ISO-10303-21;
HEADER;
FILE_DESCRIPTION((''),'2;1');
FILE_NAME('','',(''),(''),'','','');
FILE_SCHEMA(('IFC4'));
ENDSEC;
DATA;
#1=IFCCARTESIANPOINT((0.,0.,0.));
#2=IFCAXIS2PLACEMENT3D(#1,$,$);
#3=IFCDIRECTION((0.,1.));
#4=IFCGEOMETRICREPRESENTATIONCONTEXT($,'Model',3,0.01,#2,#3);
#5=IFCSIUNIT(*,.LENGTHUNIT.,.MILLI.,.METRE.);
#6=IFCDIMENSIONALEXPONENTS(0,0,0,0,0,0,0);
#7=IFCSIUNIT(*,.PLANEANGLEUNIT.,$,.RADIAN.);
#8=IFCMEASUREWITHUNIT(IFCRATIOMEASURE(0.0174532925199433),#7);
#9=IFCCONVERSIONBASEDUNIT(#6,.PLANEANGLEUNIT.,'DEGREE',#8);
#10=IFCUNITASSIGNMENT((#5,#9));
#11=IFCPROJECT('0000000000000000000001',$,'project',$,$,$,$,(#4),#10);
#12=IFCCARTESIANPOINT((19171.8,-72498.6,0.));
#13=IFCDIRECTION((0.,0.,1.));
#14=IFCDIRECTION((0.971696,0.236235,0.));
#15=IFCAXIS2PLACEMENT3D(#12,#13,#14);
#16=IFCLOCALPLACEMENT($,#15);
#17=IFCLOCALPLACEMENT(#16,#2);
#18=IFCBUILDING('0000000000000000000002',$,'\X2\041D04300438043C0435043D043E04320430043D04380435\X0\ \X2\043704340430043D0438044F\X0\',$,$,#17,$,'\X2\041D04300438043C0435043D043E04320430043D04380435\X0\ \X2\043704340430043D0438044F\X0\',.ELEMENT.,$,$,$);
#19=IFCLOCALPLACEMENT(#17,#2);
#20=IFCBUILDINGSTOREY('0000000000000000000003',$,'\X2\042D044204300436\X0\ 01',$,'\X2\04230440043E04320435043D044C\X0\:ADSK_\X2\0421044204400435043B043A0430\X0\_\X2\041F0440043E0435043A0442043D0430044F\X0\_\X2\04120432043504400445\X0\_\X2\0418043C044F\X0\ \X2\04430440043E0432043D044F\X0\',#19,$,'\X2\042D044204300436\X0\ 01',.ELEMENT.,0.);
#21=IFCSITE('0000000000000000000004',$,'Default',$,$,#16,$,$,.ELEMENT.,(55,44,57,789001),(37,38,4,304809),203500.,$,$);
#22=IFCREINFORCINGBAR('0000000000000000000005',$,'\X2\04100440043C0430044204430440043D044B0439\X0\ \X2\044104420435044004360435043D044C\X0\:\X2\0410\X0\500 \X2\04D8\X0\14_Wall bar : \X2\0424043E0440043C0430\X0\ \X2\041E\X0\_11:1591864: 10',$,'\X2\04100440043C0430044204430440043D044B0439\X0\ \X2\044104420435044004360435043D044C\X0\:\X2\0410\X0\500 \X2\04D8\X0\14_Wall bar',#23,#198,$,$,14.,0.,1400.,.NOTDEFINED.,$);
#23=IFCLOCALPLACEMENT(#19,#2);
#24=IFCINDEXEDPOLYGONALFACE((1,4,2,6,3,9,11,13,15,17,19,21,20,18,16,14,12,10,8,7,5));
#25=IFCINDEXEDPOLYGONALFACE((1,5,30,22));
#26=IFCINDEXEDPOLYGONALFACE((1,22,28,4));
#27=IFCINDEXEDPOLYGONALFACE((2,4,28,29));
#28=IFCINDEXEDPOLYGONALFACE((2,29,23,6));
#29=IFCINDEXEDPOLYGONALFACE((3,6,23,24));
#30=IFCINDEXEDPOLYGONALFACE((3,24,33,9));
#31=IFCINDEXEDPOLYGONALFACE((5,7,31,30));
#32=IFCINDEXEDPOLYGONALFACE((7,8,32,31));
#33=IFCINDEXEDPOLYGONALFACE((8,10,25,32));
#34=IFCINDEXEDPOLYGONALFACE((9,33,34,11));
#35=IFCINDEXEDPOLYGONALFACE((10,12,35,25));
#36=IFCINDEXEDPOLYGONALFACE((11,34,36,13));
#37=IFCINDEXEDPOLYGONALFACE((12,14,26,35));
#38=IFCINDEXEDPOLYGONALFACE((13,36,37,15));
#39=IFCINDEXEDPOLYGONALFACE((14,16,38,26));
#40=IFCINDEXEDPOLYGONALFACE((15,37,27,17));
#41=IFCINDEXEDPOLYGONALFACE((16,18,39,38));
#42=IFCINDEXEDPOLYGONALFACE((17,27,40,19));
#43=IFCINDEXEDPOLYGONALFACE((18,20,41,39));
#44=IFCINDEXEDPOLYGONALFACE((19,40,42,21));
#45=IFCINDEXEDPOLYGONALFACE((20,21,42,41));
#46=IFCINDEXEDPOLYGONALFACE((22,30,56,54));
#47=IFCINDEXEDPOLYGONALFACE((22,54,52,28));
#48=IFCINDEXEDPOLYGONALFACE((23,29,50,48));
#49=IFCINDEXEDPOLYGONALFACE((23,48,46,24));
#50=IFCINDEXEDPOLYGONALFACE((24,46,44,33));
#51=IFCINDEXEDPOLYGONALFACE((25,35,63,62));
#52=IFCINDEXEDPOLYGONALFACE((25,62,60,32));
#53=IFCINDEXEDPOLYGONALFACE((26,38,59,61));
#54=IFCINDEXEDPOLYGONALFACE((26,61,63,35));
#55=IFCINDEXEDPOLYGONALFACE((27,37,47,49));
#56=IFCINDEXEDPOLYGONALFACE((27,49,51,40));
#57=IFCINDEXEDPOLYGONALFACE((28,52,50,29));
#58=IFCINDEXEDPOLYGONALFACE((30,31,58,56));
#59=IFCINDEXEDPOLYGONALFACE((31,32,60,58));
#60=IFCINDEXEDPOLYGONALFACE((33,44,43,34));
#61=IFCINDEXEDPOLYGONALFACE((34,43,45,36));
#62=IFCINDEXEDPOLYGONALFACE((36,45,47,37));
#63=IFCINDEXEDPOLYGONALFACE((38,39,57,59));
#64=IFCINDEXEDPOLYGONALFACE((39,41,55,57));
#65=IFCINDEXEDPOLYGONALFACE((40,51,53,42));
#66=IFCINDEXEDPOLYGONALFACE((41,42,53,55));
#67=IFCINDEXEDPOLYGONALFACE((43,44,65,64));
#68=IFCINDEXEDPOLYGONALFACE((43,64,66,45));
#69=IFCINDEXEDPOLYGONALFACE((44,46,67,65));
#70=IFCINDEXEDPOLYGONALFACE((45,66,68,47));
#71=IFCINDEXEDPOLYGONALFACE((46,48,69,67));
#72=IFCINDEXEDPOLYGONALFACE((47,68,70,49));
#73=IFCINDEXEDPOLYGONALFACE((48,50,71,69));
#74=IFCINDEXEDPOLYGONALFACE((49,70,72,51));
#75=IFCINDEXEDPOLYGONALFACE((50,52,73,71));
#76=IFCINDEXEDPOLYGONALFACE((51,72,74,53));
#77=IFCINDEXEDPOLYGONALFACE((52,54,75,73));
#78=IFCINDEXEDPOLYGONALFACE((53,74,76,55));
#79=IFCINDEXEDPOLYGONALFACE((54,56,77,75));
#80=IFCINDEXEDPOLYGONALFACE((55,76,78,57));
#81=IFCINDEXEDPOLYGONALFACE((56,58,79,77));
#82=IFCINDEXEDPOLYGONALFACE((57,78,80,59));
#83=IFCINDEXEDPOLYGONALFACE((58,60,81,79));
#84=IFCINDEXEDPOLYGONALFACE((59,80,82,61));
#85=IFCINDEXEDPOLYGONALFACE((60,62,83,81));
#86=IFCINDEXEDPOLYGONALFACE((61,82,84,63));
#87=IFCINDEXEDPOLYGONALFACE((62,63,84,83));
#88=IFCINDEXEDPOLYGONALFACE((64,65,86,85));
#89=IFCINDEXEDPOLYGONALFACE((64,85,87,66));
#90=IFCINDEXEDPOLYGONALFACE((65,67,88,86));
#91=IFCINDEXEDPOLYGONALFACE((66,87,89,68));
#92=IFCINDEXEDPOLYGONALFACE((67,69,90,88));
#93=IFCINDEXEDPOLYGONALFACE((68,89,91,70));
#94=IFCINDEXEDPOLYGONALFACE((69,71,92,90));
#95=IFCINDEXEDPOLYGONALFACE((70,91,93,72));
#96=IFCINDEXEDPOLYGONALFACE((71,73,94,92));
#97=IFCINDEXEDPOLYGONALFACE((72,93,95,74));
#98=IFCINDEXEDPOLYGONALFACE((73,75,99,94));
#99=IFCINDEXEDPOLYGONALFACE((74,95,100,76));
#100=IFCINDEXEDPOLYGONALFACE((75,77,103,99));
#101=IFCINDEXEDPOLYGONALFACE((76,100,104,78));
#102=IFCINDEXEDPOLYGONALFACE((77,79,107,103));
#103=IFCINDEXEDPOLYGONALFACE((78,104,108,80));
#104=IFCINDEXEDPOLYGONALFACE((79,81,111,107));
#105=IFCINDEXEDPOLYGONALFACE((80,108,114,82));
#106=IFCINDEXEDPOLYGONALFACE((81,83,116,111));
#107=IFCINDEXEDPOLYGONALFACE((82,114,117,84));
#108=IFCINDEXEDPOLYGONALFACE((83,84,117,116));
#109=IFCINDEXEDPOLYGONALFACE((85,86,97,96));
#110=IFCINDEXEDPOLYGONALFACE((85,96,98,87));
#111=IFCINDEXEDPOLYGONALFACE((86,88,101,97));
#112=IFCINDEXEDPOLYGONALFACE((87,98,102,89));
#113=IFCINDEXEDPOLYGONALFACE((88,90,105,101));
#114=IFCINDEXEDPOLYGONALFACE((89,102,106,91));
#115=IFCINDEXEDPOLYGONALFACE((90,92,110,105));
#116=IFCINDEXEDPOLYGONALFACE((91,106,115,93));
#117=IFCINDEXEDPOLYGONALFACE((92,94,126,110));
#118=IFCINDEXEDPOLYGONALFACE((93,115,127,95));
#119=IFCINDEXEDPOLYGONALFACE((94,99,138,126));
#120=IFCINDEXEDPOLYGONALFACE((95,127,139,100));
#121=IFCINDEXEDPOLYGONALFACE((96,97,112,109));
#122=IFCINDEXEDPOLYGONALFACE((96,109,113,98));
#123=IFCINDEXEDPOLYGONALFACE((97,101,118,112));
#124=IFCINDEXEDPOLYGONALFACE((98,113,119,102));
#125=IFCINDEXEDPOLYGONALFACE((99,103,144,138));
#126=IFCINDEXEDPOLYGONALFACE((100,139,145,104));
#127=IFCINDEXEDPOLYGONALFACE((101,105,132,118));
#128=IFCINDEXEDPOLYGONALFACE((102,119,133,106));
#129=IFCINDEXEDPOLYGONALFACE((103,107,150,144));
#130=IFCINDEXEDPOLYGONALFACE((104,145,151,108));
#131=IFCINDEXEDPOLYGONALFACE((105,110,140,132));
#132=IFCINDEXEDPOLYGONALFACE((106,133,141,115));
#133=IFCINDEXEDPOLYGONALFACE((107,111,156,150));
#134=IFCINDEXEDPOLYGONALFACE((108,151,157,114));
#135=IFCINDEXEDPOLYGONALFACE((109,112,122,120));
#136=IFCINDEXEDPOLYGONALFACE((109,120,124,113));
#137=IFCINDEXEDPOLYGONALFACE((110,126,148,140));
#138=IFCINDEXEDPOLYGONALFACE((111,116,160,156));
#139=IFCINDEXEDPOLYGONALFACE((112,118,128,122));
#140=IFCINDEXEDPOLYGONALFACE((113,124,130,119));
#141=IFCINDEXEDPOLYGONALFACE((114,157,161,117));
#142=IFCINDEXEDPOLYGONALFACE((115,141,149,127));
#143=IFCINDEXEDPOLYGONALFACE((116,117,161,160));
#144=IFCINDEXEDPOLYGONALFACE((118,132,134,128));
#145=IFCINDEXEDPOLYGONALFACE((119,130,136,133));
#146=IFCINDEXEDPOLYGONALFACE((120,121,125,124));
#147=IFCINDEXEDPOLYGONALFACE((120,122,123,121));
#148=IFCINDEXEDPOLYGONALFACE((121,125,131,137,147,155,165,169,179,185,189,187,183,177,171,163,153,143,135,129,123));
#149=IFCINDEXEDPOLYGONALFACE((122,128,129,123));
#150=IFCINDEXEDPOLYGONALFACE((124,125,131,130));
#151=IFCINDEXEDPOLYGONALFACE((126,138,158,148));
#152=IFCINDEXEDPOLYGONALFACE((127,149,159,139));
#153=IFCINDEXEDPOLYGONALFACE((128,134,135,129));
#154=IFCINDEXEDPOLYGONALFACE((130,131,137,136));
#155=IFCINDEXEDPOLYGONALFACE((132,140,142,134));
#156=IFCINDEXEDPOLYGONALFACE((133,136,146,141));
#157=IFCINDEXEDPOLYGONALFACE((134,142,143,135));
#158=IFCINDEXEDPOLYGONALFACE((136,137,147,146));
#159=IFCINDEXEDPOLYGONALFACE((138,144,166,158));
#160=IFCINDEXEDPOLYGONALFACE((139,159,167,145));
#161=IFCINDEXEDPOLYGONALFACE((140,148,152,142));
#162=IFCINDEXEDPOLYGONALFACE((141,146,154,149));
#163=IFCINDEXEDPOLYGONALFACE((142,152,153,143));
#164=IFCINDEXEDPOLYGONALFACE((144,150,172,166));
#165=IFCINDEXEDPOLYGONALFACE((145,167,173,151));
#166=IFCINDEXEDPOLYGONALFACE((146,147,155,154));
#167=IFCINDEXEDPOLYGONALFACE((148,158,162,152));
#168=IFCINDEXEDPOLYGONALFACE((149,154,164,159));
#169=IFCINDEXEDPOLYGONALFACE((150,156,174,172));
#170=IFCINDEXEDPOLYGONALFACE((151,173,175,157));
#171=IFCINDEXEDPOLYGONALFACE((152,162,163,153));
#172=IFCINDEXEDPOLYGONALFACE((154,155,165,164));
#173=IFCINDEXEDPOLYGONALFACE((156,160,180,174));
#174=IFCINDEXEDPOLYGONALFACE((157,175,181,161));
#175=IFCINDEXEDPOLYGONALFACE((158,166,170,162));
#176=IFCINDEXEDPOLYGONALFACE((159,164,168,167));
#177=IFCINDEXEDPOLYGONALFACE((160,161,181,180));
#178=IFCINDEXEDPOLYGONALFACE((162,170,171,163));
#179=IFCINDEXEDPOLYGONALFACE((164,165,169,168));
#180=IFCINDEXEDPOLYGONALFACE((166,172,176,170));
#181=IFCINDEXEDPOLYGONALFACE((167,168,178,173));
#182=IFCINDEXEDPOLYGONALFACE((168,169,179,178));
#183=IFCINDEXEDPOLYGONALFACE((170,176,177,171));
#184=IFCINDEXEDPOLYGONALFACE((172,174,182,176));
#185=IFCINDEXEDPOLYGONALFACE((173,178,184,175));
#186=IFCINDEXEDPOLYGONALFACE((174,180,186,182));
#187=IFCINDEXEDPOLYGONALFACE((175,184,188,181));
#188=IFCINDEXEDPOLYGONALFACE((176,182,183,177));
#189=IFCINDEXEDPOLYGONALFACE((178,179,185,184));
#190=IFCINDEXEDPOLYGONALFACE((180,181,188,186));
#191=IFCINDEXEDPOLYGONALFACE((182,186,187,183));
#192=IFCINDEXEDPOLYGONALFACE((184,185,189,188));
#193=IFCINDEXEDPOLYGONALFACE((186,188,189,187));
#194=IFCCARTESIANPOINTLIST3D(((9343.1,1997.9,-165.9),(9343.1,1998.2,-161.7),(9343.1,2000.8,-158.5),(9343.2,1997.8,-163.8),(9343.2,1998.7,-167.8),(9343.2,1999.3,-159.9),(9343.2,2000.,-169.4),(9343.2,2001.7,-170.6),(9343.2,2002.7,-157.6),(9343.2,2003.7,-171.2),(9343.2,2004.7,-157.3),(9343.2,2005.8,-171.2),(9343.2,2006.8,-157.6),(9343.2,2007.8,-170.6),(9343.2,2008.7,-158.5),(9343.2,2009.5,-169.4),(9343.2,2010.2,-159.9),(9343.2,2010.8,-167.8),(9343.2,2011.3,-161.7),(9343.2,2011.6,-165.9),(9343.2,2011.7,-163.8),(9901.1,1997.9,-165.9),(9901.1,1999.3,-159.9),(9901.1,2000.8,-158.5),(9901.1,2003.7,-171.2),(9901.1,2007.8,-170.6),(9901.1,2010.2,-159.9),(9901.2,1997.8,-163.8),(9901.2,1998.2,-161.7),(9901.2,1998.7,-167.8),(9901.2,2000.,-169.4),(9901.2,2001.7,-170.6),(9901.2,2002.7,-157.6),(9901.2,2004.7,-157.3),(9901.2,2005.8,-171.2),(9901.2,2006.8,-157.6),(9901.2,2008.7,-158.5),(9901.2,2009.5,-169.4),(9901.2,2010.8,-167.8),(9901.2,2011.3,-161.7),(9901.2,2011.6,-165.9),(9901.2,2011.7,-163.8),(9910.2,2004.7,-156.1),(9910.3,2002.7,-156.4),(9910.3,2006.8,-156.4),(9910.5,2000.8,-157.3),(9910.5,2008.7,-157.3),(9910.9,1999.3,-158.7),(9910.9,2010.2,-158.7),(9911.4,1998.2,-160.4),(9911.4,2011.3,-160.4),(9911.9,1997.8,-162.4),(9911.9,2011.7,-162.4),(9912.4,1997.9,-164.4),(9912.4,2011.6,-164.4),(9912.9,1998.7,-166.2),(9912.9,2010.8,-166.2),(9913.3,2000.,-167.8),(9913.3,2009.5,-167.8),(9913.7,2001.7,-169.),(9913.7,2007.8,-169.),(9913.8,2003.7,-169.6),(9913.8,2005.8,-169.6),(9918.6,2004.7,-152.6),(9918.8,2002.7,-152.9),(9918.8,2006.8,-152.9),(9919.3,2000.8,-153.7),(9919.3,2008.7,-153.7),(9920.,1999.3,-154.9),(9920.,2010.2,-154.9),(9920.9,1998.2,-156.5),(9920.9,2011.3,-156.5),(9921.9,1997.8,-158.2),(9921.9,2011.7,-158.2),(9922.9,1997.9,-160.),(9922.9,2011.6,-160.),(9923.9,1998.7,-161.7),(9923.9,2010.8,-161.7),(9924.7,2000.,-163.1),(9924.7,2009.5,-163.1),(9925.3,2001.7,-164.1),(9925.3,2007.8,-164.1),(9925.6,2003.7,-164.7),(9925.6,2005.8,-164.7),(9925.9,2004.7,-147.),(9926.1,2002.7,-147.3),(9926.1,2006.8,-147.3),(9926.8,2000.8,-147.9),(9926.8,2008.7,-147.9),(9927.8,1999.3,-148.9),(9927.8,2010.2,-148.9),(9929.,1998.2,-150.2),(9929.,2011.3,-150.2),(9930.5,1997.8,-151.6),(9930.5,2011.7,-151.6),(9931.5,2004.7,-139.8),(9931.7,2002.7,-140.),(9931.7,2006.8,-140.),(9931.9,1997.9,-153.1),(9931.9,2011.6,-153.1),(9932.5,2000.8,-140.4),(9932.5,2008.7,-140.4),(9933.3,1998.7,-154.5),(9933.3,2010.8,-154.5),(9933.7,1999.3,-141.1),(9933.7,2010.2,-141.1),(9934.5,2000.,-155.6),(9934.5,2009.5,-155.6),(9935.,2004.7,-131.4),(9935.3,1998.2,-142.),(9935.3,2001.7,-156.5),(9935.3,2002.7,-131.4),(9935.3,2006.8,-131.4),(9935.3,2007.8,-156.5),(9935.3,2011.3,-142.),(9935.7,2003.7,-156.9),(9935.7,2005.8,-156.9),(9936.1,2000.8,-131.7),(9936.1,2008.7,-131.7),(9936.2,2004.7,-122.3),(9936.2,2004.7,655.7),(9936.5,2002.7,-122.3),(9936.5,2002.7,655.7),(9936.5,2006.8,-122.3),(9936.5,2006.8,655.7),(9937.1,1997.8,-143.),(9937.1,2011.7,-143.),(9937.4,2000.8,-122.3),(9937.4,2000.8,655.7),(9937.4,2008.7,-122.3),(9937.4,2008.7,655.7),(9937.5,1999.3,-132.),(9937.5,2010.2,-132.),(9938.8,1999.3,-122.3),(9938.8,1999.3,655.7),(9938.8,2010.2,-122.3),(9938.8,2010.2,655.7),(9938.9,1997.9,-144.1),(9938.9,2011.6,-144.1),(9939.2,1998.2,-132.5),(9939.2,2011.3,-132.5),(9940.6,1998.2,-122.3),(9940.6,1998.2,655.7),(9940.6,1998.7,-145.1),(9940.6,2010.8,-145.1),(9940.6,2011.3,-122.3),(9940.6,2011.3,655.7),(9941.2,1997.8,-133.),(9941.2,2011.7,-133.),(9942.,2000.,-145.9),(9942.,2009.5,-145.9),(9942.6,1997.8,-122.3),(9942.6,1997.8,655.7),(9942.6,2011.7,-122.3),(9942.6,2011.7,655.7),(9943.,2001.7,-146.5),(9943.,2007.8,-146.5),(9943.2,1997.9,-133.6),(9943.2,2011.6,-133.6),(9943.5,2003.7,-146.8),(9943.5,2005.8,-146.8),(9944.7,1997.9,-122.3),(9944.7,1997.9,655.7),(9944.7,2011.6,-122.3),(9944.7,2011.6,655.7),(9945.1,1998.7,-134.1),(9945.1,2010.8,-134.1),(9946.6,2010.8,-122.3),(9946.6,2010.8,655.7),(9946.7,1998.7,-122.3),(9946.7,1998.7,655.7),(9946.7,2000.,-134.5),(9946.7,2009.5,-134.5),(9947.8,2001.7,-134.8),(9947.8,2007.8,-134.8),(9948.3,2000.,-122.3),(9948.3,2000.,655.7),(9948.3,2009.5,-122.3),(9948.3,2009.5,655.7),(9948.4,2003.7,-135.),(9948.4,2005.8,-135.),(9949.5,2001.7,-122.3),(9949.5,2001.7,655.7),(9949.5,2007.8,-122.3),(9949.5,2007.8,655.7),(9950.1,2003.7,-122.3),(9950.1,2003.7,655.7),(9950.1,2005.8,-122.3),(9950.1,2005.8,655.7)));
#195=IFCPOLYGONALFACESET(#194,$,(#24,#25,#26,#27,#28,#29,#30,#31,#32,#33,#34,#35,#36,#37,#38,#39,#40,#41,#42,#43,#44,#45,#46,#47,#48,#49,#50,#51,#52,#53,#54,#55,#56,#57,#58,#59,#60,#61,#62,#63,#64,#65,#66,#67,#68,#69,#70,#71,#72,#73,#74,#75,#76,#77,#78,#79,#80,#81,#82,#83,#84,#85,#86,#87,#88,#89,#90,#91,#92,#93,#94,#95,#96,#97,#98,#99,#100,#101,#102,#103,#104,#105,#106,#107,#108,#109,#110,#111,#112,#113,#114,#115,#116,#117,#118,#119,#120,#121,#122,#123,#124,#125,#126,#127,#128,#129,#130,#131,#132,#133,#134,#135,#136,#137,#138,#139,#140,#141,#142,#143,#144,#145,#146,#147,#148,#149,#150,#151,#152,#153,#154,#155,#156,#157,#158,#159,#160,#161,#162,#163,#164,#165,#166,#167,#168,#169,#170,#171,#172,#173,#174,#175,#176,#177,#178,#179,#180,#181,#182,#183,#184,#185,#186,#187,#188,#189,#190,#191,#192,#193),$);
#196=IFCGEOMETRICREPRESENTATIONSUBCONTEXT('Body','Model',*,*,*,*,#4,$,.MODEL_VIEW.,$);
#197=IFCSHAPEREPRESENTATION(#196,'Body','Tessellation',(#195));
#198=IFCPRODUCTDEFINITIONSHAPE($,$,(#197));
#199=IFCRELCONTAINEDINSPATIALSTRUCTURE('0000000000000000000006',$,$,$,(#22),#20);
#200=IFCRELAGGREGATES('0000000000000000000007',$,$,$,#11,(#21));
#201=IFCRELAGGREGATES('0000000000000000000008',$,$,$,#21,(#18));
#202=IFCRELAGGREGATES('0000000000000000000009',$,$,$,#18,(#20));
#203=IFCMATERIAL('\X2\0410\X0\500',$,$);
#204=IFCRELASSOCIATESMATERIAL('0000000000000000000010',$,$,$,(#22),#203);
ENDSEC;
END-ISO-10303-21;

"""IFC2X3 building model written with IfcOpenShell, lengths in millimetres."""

from ifc_helpers import new_model, entity, si_unit, converted_unit, direction, frame, origin, place, context, subcontext, project, spatial, material, element, save


model = new_model("IFC2X3")

# Units and contexts
model_context = context("Model", 3, precision=0.01, world=origin(), true_north=direction((0.0, 1.0)))
body_context = subcontext(model_context, "Body", "Model", "MODEL_VIEW")
ifc_project = project(units=[si_unit("LENGTHUNIT", "METRE", prefix="MILLI"), converted_unit("PLANEANGLEUNIT", "DEGREE", entity("IfcRatioMeasure", 0.0174532925199433), si_unit("PLANEANGLEUNIT", "RADIAN"), dimensions=[0, 0, 0, 0, 0, 0, 0])], contexts=[model_context])

# Site, building, storey
site_placement = place(None, frame((19171.8, -72498.6, 0.0), z_axis=(0.0, 0.0, 1.0), x_axis=(0.971696, 0.236235, 0.0)))
site = spatial("IfcSite", under=ifc_project, at=site_placement, Name="Default", CompositionType="ELEMENT", RefLatitude=(55, 44, 57, 789001), RefLongitude=(37, 38, 4, 304809), RefElevation=203500.0)
building_placement = place(site_placement, origin())
building = spatial("IfcBuilding", under=site, at=building_placement, Name="Наименование здания", LongName="Наименование здания", CompositionType="ELEMENT")
storey_placement = place(building_placement, origin())
storey = spatial("IfcBuildingStorey", under=building, at=storey_placement, Name="Этаж 01", ObjectType="Уровень:ADSK_Стрелка_Проектная_Вверх_Имя уровня", LongName="Этаж 01", CompositionType="ELEMENT", Elevation=0.0)

# Reinforcing bar
ifc_material = material(Name="А500")
placement = place(storey_placement, origin())
element("IfcReinforcingBar", 1, at=placement, inside=storey, material=ifc_material, Name="Арматурный стержень:А500 Ә14_Wall bar : Форма О_11:1591864: 10", ObjectType="Арматурный стержень:А500 Ә14_Wall bar", BarLength=1400.0, BarRole="NOTDEFINED", CrossSectionArea=0.0, NominalDiameter=14.0, context=body_context, shape_type="AdvancedSweptSolid", body=[
    entity("IfcSweptDiskSolid", entity("IfcCompositeCurve", [entity("IfcCompositeCurveSegment", "CONTINUOUS", True, entity("IfcPolyline", [entity("IfcCartesianPoint", [9943.1, 2004.7, 655.7]), entity("IfcCartesianPoint", [9943.1, 2004.7, -122.3])])), entity("IfcCompositeCurveSegment", "CONTINUOUS", True, entity("IfcTrimmedCurve", entity("IfcCircle", entity("IfcAxis2Placement3D", entity("IfcCartesianPoint", [9901.1, 2004.7, -122.3]), entity("IfcDirection", [0.0, 1.0, 0.0]), entity("IfcDirection", [0.0, 0.0, -1.0])), 42.0), [entity("IfcParameterValue", 270.0)], [entity("IfcParameterValue", 360.0)], True, "PARAMETER")), entity("IfcCompositeCurveSegment", "CONTINUOUS", True, entity("IfcPolyline", [entity("IfcCartesianPoint", [9901.1, 2004.7, -164.3]), entity("IfcCartesianPoint", [9343.1, 2004.7, -164.3])]))], False), 7.0, None, 0.0, 92.0),
])

save(model, "model.ifc")
